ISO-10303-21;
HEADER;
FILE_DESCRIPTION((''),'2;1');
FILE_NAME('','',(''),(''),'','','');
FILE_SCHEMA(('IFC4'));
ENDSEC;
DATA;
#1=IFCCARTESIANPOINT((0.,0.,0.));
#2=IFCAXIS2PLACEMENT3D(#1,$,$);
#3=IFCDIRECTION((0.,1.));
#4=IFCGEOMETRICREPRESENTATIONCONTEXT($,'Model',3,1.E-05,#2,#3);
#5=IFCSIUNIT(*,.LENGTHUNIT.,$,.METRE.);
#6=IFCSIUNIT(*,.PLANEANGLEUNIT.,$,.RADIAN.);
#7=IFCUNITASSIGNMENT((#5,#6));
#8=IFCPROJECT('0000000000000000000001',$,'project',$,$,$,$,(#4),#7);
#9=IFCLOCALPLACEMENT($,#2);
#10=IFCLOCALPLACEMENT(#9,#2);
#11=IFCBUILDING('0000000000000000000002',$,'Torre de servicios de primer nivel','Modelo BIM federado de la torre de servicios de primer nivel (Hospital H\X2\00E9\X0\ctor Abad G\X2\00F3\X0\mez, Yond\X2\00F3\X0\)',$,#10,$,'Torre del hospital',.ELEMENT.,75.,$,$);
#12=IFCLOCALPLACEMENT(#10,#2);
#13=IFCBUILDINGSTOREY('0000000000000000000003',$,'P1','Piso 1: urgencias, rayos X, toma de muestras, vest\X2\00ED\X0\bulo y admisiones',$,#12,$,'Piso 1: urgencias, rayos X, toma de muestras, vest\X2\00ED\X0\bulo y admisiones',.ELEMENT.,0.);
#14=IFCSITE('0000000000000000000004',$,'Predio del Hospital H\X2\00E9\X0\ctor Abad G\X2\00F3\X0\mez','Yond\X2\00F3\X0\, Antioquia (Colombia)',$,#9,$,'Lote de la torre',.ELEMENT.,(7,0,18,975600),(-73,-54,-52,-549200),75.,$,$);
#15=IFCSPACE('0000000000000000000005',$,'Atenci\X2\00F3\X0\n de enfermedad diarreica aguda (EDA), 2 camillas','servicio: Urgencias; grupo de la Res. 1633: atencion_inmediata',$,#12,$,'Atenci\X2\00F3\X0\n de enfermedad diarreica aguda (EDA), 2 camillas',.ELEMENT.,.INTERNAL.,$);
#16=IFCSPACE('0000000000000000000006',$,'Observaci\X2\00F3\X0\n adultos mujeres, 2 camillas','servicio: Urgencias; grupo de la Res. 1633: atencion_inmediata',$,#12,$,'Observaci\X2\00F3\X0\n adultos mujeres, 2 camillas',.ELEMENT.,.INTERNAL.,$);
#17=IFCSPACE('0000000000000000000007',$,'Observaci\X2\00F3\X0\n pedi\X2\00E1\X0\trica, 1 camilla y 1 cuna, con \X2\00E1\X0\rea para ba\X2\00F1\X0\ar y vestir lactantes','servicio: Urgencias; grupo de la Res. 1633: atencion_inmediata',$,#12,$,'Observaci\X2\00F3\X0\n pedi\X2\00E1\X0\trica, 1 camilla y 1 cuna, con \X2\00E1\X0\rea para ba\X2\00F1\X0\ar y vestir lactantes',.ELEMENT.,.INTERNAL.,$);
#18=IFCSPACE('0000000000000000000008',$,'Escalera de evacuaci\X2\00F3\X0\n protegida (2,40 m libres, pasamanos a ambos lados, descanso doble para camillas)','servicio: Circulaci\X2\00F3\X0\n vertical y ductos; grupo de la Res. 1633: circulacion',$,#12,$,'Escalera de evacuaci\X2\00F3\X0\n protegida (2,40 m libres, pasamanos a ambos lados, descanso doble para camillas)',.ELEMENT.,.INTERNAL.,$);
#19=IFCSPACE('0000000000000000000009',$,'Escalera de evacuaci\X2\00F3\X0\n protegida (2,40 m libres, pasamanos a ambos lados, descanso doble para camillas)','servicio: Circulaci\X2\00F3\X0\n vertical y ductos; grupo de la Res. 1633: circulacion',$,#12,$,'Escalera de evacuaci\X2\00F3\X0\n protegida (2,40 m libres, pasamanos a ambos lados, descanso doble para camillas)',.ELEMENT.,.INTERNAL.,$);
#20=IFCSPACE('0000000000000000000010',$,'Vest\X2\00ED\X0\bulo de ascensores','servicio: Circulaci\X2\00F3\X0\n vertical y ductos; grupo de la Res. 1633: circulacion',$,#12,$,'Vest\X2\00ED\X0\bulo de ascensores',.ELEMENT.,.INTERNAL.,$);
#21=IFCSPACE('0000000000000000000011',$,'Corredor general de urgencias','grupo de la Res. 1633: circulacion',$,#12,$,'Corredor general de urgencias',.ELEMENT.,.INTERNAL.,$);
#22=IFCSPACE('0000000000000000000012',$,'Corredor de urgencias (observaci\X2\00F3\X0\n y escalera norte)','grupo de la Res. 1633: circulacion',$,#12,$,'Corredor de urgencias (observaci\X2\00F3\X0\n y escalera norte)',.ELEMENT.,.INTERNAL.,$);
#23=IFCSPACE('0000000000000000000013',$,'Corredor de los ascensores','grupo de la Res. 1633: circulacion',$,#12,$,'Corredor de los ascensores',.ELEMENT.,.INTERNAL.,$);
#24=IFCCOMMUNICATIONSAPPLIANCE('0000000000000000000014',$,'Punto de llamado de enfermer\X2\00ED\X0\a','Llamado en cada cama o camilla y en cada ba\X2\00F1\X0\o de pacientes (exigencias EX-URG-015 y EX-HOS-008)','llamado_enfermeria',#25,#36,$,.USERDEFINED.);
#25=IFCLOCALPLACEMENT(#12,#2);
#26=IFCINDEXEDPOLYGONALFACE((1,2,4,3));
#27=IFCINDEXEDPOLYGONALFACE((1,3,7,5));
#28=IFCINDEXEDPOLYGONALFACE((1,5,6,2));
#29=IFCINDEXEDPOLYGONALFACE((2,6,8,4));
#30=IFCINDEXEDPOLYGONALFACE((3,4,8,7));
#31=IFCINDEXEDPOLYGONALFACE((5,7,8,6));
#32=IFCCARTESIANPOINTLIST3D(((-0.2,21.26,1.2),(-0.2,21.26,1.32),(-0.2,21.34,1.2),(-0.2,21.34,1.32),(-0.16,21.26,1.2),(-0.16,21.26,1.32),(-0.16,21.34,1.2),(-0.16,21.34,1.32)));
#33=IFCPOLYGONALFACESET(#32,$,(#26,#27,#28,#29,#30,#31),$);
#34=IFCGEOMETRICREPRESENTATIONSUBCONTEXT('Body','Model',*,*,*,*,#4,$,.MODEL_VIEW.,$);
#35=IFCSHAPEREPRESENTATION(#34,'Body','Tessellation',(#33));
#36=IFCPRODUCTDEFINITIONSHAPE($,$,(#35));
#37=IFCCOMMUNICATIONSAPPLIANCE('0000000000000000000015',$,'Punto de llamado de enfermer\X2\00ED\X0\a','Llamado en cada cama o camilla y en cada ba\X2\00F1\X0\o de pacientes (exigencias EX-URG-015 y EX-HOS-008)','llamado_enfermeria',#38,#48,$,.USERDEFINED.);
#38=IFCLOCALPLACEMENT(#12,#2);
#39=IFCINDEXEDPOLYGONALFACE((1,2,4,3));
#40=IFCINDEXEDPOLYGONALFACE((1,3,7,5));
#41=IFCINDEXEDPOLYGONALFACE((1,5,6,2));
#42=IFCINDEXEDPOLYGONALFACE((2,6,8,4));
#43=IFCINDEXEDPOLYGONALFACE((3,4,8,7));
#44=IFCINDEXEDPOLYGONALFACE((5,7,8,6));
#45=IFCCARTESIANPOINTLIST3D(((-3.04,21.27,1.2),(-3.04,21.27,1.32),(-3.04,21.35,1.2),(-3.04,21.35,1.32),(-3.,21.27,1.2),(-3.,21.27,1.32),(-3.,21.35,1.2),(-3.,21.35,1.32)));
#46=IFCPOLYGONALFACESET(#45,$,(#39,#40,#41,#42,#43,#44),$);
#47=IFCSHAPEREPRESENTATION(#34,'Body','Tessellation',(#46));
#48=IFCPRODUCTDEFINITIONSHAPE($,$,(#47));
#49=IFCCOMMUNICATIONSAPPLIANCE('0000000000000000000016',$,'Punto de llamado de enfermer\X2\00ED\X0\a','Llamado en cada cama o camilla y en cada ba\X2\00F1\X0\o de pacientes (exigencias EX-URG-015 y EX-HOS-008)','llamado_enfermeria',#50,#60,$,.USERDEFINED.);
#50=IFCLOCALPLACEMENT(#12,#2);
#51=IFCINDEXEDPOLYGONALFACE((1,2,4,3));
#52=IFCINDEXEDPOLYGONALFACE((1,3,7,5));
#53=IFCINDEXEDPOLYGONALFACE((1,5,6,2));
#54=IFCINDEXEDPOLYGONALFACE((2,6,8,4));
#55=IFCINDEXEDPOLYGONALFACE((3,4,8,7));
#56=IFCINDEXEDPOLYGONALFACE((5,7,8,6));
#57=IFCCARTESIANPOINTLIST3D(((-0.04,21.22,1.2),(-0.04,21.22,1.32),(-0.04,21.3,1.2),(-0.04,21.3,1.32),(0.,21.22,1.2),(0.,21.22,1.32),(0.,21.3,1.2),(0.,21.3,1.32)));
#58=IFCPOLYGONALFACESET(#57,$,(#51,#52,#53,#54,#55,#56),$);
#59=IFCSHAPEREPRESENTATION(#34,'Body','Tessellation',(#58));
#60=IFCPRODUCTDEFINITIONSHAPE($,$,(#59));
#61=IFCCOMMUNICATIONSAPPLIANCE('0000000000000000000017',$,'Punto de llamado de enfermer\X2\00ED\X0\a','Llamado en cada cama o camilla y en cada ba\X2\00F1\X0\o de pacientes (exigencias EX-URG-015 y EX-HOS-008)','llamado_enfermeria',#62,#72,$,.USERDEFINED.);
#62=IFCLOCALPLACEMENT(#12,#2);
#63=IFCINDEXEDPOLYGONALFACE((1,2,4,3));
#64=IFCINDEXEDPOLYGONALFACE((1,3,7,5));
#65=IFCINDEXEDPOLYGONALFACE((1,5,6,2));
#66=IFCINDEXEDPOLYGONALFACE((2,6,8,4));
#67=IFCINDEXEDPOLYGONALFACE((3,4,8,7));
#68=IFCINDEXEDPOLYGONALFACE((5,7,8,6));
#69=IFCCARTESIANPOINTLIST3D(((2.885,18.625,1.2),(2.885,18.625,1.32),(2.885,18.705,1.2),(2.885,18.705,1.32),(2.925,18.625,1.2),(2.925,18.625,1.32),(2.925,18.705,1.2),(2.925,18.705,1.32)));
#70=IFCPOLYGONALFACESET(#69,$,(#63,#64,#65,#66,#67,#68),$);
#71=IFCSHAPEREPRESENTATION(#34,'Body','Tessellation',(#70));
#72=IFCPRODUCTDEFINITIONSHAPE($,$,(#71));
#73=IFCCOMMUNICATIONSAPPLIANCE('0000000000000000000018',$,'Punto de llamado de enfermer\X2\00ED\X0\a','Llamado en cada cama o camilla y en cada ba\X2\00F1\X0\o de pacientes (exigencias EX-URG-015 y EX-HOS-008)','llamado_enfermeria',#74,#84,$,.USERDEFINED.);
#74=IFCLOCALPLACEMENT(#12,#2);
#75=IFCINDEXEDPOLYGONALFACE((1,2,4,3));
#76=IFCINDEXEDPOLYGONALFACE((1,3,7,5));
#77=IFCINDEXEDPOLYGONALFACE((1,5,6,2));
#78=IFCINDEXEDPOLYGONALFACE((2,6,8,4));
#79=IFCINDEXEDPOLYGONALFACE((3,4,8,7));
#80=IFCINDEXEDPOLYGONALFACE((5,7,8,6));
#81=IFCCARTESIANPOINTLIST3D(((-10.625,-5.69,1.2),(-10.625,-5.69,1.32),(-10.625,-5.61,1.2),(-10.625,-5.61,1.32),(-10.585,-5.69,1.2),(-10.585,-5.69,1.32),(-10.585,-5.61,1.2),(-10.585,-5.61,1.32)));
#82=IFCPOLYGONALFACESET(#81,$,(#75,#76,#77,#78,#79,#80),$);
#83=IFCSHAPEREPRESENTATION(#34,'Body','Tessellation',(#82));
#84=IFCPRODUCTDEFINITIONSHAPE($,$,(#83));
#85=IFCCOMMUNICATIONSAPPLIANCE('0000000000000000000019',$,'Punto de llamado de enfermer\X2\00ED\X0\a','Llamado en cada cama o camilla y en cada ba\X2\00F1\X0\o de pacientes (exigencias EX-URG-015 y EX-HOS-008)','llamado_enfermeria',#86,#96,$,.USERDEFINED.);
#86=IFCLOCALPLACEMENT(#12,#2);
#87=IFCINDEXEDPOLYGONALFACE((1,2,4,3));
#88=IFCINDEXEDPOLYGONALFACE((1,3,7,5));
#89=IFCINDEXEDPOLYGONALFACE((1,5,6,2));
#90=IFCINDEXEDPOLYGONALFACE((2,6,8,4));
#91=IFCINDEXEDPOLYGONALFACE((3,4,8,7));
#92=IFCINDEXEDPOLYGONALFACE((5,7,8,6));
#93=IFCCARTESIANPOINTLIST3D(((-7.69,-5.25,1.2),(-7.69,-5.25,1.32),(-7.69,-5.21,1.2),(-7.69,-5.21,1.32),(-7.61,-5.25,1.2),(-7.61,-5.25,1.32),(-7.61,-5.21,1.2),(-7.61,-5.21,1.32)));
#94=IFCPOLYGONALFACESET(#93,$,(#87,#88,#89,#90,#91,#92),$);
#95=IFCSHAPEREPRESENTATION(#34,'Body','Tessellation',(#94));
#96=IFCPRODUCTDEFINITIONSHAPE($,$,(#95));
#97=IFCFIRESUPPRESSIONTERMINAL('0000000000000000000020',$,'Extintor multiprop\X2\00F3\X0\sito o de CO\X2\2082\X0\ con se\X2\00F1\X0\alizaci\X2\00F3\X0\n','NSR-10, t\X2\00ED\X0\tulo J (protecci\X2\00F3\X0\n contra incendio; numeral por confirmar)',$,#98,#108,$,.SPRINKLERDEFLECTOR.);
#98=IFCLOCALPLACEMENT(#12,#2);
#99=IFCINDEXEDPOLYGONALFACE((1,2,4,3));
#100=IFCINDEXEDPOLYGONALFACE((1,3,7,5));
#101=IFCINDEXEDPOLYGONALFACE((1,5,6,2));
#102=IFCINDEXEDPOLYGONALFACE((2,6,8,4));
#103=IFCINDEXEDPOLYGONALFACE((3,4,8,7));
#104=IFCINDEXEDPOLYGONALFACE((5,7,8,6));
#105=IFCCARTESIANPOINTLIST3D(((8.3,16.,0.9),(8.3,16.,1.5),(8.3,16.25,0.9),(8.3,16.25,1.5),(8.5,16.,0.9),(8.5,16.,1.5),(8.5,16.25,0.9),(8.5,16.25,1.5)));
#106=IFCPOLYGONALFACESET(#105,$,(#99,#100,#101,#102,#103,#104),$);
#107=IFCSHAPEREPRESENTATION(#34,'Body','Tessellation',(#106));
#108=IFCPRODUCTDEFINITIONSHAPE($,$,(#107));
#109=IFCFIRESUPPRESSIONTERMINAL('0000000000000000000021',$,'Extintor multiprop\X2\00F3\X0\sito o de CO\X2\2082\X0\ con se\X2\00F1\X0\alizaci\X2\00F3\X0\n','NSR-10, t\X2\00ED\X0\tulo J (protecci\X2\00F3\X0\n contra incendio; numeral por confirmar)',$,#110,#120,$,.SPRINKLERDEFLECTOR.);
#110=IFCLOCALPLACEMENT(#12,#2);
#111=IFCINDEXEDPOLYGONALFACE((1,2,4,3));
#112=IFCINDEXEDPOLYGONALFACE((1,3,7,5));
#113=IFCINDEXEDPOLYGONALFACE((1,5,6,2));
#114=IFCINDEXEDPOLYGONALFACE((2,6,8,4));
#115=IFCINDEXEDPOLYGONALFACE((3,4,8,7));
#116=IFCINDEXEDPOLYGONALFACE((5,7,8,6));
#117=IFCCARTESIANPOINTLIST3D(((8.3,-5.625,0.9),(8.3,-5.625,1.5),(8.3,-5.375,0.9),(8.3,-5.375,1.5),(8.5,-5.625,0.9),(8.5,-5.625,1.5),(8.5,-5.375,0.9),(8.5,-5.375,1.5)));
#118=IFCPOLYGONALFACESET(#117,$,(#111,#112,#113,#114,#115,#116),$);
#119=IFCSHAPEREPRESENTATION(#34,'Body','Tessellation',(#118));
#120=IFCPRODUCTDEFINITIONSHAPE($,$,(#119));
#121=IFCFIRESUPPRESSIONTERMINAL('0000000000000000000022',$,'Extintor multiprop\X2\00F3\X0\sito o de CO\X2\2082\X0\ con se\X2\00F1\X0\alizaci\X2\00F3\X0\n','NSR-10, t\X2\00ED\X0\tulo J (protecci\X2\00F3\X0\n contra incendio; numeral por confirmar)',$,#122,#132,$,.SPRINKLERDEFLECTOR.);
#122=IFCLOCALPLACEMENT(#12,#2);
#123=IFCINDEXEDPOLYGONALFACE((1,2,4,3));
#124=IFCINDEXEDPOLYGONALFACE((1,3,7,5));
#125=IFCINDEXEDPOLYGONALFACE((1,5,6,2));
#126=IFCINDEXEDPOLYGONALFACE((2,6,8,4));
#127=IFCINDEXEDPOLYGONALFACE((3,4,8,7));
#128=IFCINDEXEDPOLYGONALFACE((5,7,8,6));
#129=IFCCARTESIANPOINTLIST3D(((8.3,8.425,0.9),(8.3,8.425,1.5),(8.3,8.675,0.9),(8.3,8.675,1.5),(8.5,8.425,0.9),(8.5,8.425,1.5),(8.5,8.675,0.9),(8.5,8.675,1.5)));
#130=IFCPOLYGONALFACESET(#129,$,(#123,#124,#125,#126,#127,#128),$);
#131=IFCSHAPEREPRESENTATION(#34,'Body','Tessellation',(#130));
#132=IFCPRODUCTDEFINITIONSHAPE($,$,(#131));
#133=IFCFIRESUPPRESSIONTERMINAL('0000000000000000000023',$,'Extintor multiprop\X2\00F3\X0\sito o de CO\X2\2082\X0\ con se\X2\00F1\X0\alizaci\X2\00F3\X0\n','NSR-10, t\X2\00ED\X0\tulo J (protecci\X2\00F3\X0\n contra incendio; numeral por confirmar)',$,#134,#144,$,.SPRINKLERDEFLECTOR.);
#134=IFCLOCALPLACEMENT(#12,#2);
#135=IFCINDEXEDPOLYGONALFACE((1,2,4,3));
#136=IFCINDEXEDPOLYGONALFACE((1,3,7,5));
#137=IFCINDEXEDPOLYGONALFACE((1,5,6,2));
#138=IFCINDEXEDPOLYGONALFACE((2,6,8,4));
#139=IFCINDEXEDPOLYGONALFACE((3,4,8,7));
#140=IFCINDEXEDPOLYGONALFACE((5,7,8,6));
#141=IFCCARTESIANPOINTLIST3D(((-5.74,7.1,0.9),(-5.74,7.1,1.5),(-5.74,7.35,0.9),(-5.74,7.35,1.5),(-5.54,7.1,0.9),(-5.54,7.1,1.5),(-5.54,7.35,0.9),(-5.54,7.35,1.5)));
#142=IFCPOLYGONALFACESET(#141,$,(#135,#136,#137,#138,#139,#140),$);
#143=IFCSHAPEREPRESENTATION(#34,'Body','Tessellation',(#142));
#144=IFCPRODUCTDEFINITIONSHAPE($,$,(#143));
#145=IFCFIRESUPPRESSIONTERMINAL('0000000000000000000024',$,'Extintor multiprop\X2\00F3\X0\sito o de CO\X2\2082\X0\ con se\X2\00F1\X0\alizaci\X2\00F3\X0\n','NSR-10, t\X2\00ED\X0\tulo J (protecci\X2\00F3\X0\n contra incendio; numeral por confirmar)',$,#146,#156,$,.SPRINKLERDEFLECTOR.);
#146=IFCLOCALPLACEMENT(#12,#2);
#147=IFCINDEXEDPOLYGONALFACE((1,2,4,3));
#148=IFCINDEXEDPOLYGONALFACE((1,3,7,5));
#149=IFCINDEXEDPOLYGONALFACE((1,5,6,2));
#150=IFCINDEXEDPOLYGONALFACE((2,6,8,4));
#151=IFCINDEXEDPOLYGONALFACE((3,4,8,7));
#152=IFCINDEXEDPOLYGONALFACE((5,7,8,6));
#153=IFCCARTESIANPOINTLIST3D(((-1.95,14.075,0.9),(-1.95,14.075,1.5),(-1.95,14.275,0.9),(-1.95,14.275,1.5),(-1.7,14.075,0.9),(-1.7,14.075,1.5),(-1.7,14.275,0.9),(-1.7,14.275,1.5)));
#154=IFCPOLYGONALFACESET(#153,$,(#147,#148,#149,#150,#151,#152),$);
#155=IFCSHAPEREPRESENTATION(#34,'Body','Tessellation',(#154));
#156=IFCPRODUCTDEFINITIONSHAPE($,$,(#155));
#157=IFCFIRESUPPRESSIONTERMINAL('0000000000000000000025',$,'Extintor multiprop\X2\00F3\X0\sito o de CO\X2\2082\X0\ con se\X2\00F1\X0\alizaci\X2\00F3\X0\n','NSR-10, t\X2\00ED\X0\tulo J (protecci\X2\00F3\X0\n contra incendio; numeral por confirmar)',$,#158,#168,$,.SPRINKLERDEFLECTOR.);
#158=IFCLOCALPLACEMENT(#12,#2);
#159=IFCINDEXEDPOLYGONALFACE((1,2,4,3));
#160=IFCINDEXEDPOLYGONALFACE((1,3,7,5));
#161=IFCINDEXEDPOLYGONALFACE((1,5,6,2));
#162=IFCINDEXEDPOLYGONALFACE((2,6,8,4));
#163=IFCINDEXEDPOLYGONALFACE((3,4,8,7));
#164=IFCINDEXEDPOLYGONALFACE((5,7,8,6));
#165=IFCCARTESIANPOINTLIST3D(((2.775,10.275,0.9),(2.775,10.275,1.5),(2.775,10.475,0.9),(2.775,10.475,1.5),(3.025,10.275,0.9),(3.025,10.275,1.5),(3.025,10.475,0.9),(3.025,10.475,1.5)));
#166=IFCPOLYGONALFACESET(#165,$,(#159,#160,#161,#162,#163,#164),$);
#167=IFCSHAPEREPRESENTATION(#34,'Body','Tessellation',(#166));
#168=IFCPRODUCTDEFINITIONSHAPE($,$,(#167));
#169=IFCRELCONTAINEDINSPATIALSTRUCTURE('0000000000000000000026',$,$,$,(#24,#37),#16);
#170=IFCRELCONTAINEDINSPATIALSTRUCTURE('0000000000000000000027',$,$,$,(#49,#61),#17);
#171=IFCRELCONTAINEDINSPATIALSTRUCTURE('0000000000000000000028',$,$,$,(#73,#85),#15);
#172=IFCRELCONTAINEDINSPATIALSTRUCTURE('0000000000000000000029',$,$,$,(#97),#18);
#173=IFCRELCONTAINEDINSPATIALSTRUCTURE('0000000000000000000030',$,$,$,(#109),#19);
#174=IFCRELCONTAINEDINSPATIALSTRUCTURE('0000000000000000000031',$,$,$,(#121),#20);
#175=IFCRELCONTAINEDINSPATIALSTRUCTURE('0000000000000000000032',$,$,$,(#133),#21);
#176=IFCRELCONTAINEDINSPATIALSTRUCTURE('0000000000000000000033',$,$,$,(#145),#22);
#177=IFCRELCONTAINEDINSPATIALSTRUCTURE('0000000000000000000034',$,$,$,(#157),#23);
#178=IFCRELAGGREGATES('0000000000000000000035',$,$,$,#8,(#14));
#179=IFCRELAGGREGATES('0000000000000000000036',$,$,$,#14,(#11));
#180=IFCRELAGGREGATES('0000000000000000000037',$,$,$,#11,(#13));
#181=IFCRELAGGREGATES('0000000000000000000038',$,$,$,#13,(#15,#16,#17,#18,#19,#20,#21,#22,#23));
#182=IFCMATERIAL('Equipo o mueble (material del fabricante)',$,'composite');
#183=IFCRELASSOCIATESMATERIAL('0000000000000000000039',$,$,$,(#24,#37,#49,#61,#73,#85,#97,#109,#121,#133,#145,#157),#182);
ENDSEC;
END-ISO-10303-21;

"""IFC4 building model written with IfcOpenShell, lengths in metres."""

from ifc_helpers import new_model, si_unit, direction, frame, origin, place, context, subcontext, project, spatial, rectangle, extrude, material, element, save


model = new_model("IFC4")

# Units and contexts
model_context = context("Model", 3, precision=1e-05, world=origin(), true_north=direction((0.0, 1.0)))
body_context = subcontext(model_context, "Body", "Model", "MODEL_VIEW")
ifc_project = project(units=[si_unit("LENGTHUNIT", "METRE"), si_unit("PLANEANGLEUNIT", "RADIAN")], contexts=[model_context])

# Site, building, storey
site_placement = place(None, origin())
site = spatial("IfcSite", under=ifc_project, at=site_placement, Name="Predio del Hospital Héctor Abad Gómez", Description="Yondó, Antioquia (Colombia)", LongName="Lote de la torre", CompositionType="ELEMENT", RefLatitude=(7, 0, 18, 975600), RefLongitude=(-73, -54, -52, -549200), RefElevation=75.0)
building_placement = place(site_placement, origin())
building = spatial("IfcBuilding", under=site, at=building_placement, Name="Torre de servicios de primer nivel", Description="Modelo BIM federado de la torre de servicios de primer nivel (Hospital Héctor Abad Gómez, Yondó)", LongName="Torre del hospital", CompositionType="ELEMENT", ElevationOfRefHeight=75.0)
placement = place(building_placement, origin())
storey = spatial("IfcBuildingStorey", under=building, at=placement, Name="P1", Description="Piso 1: urgencias, rayos X, toma de muestras, vestíbulo y admisiones", LongName="Piso 1: urgencias, rayos X, toma de muestras, vestíbulo y admisiones", CompositionType="ELEMENT", Elevation=0.0)

# Shared definitions
ifc_material = material(Name="Equipo o mueble (material del fabricante)", Category="composite")

# Shared definitions
space_1 = spatial("IfcSpace", under=storey, at=placement, Name="Atención de enfermedad diarreica aguda (EDA), 2 camillas", Description="servicio: Urgencias; grupo de la Res. 1633: atencion_inmediata", LongName="Atención de enfermedad diarreica aguda (EDA), 2 camillas", CompositionType="ELEMENT", PredefinedType="INTERNAL")

# Shared definitions
space_2 = spatial("IfcSpace", under=storey, at=placement, Name="Observación adultos mujeres, 2 camillas", Description="servicio: Urgencias; grupo de la Res. 1633: atencion_inmediata", LongName="Observación adultos mujeres, 2 camillas", CompositionType="ELEMENT", PredefinedType="INTERNAL")

# Communications appliances
element("IfcCommunicationsAppliance", 1, at=placement, inside=space_2, material=ifc_material, Name="Punto de llamado de enfermería", Description="Llamado en cada cama o camilla y en cada baño de pacientes (exigencias EX-URG-015 y EX-HOS-008)", ObjectType="llamado_enfermeria", PredefinedType="USERDEFINED", context=body_context, shape_type="SweptSolid", body=[
    extrude(rectangle(XDim=0.08, YDim=0.04), frame((-0.18, 21.3, 1.2), z_axis=(0.0, 0.0, 1.0), x_axis=(0.0, 1.0, 0.0)), (0.0, 0.0, 1.0), 0.12),
])
element("IfcCommunicationsAppliance", 2, at=placement, inside=space_2, material=ifc_material, Name="Punto de llamado de enfermería", Description="Llamado en cada cama o camilla y en cada baño de pacientes (exigencias EX-URG-015 y EX-HOS-008)", ObjectType="llamado_enfermeria", PredefinedType="USERDEFINED", context=body_context, shape_type="SweptSolid", body=[
    extrude(rectangle(XDim=0.08, YDim=0.04), frame((-3.02, 21.31, 1.2), z_axis=(0.0, 0.0, 1.0), x_axis=(0.0, -1.0, 0.0)), (0.0, 0.0, 1.0), 0.12),
])

# Shared definitions
space_3 = spatial("IfcSpace", under=storey, at=placement, Name="Observación pediátrica, 1 camilla y 1 cuna, con área para bañar y vestir lactantes", Description="servicio: Urgencias; grupo de la Res. 1633: atencion_inmediata", LongName="Observación pediátrica, 1 camilla y 1 cuna, con área para bañar y vestir lactantes", CompositionType="ELEMENT", PredefinedType="INTERNAL")

# Communications appliances
element("IfcCommunicationsAppliance", 3, at=placement, inside=space_3, material=ifc_material, Name="Punto de llamado de enfermería", Description="Llamado en cada cama o camilla y en cada baño de pacientes (exigencias EX-URG-015 y EX-HOS-008)", ObjectType="llamado_enfermeria", PredefinedType="USERDEFINED", context=body_context, shape_type="SweptSolid", body=[
    extrude(rectangle(XDim=0.08, YDim=0.04), frame((-0.02, 21.26, 1.2), z_axis=(0.0, 0.0, 1.0), x_axis=(0.0, -1.0, 0.0)), (0.0, 0.0, 1.0), 0.12),
])
element("IfcCommunicationsAppliance", 4, at=placement, inside=space_3, material=ifc_material, Name="Punto de llamado de enfermería", Description="Llamado en cada cama o camilla y en cada baño de pacientes (exigencias EX-URG-015 y EX-HOS-008)", ObjectType="llamado_enfermeria", PredefinedType="USERDEFINED", context=body_context, shape_type="SweptSolid", body=[
    extrude(rectangle(XDim=0.08, YDim=0.04), frame((2.905, 18.665, 1.2), z_axis=(0.0, 0.0, 1.0), x_axis=(0.0, 1.0, 0.0)), (0.0, 0.0, 1.0), 0.12),
])
element("IfcCommunicationsAppliance", 5, at=placement, inside=space_1, material=ifc_material, Name="Punto de llamado de enfermería", Description="Llamado en cada cama o camilla y en cada baño de pacientes (exigencias EX-URG-015 y EX-HOS-008)", ObjectType="llamado_enfermeria", PredefinedType="USERDEFINED", context=body_context, shape_type="SweptSolid", body=[
    extrude(rectangle(XDim=0.08, YDim=0.04), frame((-10.605, -5.65, 1.2), z_axis=(0.0, 0.0, 1.0), x_axis=(0.0, -1.0, 0.0)), (0.0, 0.0, 1.0), 0.12),
])
element("IfcCommunicationsAppliance", 6, at=placement, inside=space_1, material=ifc_material, Name="Punto de llamado de enfermería", Description="Llamado en cada cama o camilla y en cada baño de pacientes (exigencias EX-URG-015 y EX-HOS-008)", ObjectType="llamado_enfermeria", PredefinedType="USERDEFINED", context=body_context, shape_type="SweptSolid", body=[
    extrude(rectangle(XDim=0.08, YDim=0.04), frame((-7.65, -5.23, 1.2), z_axis=(0.0, 0.0, 1.0), x_axis=(-1.0, 0.0, 0.0)), (0.0, 0.0, 1.0), 0.12),
])

# Shared definitions
space_4 = spatial("IfcSpace", under=storey, at=placement, Name="Escalera de evacuación protegida (2,40 m libres, pasamanos a ambos lados, descanso doble para camillas)", Description="servicio: Circulación vertical y ductos; grupo de la Res. 1633: circulacion", LongName="Escalera de evacuación protegida (2,40 m libres, pasamanos a ambos lados, descanso doble para camillas)", CompositionType="ELEMENT", PredefinedType="INTERNAL")

# Fire suppression terminal
element("IfcFireSuppressionTerminal", 7, at=placement, inside=space_4, material=ifc_material, Name="Extintor multipropósito o de CO₂ con señalización", Description="NSR-10, título J (protección contra incendio; numeral por confirmar)", PredefinedType="SPRINKLERDEFLECTOR", context=body_context, shape_type="SweptSolid", body=[
    extrude(rectangle(XDim=0.25, YDim=0.2), frame((8.4, 16.125, 0.9), z_axis=(0.0, 0.0, 1.0), x_axis=(0.0, 1.0, 0.0)), (0.0, 0.0, 1.0), 0.6),
])

# Shared definitions
space_5 = spatial("IfcSpace", under=storey, at=placement, Name="Escalera de evacuación protegida (2,40 m libres, pasamanos a ambos lados, descanso doble para camillas)", Description="servicio: Circulación vertical y ductos; grupo de la Res. 1633: circulacion", LongName="Escalera de evacuación protegida (2,40 m libres, pasamanos a ambos lados, descanso doble para camillas)", CompositionType="ELEMENT", PredefinedType="INTERNAL")

# Fire suppression terminal
element("IfcFireSuppressionTerminal", 8, at=placement, inside=space_5, material=ifc_material, Name="Extintor multipropósito o de CO₂ con señalización", Description="NSR-10, título J (protección contra incendio; numeral por confirmar)", PredefinedType="SPRINKLERDEFLECTOR", context=body_context, shape_type="SweptSolid", body=[
    extrude(rectangle(XDim=0.25, YDim=0.2), frame((8.4, -5.5, 0.9), z_axis=(0.0, 0.0, 1.0), x_axis=(0.0, 1.0, 0.0)), (0.0, 0.0, 1.0), 0.6),
])

# Shared definitions
space_6 = spatial("IfcSpace", under=storey, at=placement, Name="Vestíbulo de ascensores", Description="servicio: Circulación vertical y ductos; grupo de la Res. 1633: circulacion", LongName="Vestíbulo de ascensores", CompositionType="ELEMENT", PredefinedType="INTERNAL")

# Fire suppression terminal
element("IfcFireSuppressionTerminal", 9, at=placement, inside=space_6, material=ifc_material, Name="Extintor multipropósito o de CO₂ con señalización", Description="NSR-10, título J (protección contra incendio; numeral por confirmar)", PredefinedType="SPRINKLERDEFLECTOR", context=body_context, shape_type="SweptSolid", body=[
    extrude(rectangle(XDim=0.25, YDim=0.2), frame((8.4, 8.55, 0.9), z_axis=(0.0, 0.0, 1.0), x_axis=(0.0, 1.0, 0.0)), (0.0, 0.0, 1.0), 0.6),
])

# Shared definitions
space_7 = spatial("IfcSpace", under=storey, at=placement, Name="Corredor general de urgencias", Description="grupo de la Res. 1633: circulacion", LongName="Corredor general de urgencias", CompositionType="ELEMENT", PredefinedType="INTERNAL")

# Fire suppression terminal
element("IfcFireSuppressionTerminal", 10, at=placement, inside=space_7, material=ifc_material, Name="Extintor multipropósito o de CO₂ con señalización", Description="NSR-10, título J (protección contra incendio; numeral por confirmar)", PredefinedType="SPRINKLERDEFLECTOR", context=body_context, shape_type="SweptSolid", body=[
    extrude(rectangle(XDim=0.25, YDim=0.2), frame((-5.64, 7.225, 0.9), z_axis=(0.0, 0.0, 1.0), x_axis=(0.0, -1.0, 0.0)), (0.0, 0.0, 1.0), 0.6),
])

# Shared definitions
space_8 = spatial("IfcSpace", under=storey, at=placement, Name="Corredor de urgencias (observación y escalera norte)", Description="grupo de la Res. 1633: circulacion", LongName="Corredor de urgencias (observación y escalera norte)", CompositionType="ELEMENT", PredefinedType="INTERNAL")

# Fire suppression terminal
element("IfcFireSuppressionTerminal", 11, at=placement, inside=space_8, material=ifc_material, Name="Extintor multipropósito o de CO₂ con señalización", Description="NSR-10, título J (protección contra incendio; numeral por confirmar)", PredefinedType="SPRINKLERDEFLECTOR", context=body_context, shape_type="SweptSolid", body=[
    extrude(rectangle(XDim=0.25, YDim=0.2), frame((-1.825, 14.175, 0.9)), (0.0, 0.0, 1.0), 0.6),
])

# Shared definitions
space_9 = spatial("IfcSpace", under=storey, at=placement, Name="Corredor de los ascensores", Description="grupo de la Res. 1633: circulacion", LongName="Corredor de los ascensores", CompositionType="ELEMENT", PredefinedType="INTERNAL")

# Fire suppression terminal
element("IfcFireSuppressionTerminal", 12, at=placement, inside=space_9, material=ifc_material, Name="Extintor multipropósito o de CO₂ con señalización", Description="NSR-10, título J (protección contra incendio; numeral por confirmar)", PredefinedType="SPRINKLERDEFLECTOR", context=body_context, shape_type="SweptSolid", body=[
    extrude(rectangle(XDim=0.25, YDim=0.2), frame((2.9, 10.375, 0.9), z_axis=(0.0, 0.0, 1.0), x_axis=(-1.0, 0.0, 0.0)), (0.0, 0.0, 1.0), 0.6),
])

save(model, "model.ifc")
